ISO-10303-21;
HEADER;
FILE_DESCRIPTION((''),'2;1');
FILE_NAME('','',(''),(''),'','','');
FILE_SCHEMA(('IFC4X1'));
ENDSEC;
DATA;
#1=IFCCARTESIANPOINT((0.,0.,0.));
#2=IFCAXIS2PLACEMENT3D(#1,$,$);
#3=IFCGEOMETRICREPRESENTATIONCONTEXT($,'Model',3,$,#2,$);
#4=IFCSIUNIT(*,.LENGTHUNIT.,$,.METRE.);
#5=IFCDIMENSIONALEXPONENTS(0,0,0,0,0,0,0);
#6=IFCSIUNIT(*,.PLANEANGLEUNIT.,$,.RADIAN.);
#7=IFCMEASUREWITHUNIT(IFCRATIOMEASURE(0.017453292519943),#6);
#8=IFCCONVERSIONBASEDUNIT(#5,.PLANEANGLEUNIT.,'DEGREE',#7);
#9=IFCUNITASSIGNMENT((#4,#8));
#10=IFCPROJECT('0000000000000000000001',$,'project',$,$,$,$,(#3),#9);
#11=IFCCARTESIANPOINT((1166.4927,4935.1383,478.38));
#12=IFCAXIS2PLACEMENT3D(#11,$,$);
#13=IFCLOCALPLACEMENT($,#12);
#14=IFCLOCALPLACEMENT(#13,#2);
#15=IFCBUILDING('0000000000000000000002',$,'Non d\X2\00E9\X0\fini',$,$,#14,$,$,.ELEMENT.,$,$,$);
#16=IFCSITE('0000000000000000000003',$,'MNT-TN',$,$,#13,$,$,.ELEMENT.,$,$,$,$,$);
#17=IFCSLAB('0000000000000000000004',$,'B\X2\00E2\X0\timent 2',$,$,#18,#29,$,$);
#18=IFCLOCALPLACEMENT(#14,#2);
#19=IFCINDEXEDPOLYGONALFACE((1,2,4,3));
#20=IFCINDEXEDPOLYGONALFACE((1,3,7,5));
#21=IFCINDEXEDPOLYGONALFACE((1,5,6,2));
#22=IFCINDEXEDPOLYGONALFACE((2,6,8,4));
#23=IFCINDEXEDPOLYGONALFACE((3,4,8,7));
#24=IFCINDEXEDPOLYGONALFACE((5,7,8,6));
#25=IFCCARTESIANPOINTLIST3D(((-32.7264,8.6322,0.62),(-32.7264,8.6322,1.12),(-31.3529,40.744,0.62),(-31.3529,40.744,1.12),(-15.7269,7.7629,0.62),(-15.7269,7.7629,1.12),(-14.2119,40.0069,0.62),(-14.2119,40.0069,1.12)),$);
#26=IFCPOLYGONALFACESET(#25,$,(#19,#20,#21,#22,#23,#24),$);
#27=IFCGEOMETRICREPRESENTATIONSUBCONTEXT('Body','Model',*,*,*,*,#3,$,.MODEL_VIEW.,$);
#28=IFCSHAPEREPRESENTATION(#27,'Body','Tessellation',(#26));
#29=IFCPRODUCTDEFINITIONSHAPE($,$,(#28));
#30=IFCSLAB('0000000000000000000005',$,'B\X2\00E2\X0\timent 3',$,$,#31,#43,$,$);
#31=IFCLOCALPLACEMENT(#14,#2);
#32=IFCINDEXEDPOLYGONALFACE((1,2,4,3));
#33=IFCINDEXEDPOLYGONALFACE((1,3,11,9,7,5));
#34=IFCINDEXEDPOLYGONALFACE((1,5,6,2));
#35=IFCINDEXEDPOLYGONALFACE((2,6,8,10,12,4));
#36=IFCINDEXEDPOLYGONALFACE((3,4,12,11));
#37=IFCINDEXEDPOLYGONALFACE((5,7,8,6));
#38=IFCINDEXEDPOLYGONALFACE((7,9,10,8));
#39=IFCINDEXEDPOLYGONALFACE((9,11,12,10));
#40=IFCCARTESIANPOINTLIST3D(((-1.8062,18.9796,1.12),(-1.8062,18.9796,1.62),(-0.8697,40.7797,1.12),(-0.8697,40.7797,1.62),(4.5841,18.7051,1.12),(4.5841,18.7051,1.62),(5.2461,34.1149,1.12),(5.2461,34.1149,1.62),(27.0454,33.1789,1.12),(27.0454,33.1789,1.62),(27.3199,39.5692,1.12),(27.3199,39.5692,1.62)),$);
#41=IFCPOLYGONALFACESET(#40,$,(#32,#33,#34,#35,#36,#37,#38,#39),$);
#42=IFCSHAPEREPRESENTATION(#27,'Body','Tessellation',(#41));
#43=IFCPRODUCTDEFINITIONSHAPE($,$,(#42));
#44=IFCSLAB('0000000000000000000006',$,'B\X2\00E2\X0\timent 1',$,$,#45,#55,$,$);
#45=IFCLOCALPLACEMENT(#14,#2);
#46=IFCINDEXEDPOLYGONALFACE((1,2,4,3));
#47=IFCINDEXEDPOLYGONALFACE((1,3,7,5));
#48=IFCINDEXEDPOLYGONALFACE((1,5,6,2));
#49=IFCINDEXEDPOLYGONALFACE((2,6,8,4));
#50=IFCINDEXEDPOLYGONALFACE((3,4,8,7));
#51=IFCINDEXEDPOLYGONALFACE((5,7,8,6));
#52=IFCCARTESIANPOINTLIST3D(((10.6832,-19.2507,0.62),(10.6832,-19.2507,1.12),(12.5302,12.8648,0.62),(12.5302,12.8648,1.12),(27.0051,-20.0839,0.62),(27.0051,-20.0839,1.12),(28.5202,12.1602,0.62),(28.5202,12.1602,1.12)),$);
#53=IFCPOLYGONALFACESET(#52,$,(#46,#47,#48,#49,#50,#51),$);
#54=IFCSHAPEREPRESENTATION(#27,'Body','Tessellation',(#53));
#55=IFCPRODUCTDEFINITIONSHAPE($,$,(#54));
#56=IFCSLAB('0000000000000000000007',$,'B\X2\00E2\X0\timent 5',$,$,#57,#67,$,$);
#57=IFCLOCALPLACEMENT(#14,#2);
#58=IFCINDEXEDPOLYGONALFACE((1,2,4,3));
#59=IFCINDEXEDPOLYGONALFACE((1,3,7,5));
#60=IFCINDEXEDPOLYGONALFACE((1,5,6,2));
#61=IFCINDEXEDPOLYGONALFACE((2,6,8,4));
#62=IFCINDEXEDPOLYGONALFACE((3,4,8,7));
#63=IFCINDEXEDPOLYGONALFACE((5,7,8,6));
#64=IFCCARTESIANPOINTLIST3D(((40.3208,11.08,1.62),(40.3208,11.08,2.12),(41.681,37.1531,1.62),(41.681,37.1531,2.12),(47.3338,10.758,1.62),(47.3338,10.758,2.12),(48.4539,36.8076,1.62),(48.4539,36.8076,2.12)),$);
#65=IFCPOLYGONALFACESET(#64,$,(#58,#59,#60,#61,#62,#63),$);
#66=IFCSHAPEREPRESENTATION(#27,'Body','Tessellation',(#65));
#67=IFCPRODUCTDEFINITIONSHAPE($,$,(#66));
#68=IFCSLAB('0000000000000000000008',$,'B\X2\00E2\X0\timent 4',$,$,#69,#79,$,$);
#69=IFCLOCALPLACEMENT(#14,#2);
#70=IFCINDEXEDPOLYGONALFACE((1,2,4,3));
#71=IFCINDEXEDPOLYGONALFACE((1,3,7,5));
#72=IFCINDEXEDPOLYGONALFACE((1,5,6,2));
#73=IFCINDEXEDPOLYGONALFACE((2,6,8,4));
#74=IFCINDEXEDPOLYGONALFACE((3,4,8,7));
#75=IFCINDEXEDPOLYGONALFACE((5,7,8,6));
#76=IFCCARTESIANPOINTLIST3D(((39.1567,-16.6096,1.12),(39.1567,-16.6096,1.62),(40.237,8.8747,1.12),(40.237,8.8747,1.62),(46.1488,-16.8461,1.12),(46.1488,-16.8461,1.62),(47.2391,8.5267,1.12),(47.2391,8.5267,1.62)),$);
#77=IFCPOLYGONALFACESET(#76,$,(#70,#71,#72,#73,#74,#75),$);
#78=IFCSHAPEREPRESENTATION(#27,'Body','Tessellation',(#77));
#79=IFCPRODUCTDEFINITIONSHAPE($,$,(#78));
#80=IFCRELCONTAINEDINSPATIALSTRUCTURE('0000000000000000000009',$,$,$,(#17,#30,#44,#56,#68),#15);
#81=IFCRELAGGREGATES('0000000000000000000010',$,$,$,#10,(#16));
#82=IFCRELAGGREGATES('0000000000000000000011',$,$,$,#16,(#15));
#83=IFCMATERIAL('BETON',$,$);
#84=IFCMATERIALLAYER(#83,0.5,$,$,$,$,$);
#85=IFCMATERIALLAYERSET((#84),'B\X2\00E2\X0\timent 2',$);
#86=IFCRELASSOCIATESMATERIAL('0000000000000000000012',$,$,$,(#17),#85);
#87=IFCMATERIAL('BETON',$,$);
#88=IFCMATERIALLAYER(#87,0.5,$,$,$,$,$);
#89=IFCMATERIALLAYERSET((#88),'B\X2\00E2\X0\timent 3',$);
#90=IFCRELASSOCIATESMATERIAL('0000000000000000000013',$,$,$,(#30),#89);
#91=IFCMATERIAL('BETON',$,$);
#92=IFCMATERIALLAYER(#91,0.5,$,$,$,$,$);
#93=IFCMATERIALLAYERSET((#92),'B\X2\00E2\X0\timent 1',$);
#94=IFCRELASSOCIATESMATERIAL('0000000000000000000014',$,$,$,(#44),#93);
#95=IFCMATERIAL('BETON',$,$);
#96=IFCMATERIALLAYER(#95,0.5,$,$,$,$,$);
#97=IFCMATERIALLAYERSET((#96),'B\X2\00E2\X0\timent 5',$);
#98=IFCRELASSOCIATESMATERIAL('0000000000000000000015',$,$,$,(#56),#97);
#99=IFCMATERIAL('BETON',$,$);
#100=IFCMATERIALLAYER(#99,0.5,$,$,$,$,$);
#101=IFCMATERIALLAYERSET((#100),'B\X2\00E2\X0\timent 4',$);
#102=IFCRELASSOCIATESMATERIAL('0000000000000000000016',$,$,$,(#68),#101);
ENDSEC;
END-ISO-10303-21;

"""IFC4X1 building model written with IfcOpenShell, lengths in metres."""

from ifc_helpers import new_model, entity, si_unit, converted_unit, frame, origin, place, context, subcontext, project, spatial, polyline, outline, extrude, material, layer, layer_set, layer_usage, element, save


model = new_model("IFC4X1")

# Units and contexts
model_context = context("Model", 3, world=origin())
body_context = subcontext(model_context, "Body", "Model", "MODEL_VIEW")
ifc_project = project(units=[si_unit("LENGTHUNIT", "METRE"), converted_unit("PLANEANGLEUNIT", "DEGREE", entity("IfcRatioMeasure", 0.017453292519943), si_unit("PLANEANGLEUNIT", "RADIAN"), dimensions=[0, 0, 0, 0, 0, 0, 0])], contexts=[model_context])

# Site, building
site_placement = place(None, frame((1166.4927, 4935.1383, 478.38)))
site = spatial("IfcSite", under=ifc_project, at=site_placement, Name="MNT-TN", CompositionType="ELEMENT")
building_placement = place(site_placement, origin())
building = spatial("IfcBuilding", under=site, at=building_placement, Name="Non défini", CompositionType="ELEMENT")

# Slabs
ifc_material_1 = material(Name="BETON")
ifc_layer_1 = layer(ifc_material_1, 0.5)
ifc_layer_set_1 = layer_set([ifc_layer_1], Name="Bâtiment 2")
ifc_layer_usage_1 = layer_usage(ifc_layer_set_1, "AXIS3", "POSITIVE", 0.0)
slab_1_placement = place(building_placement, origin())
element("IfcSlab", 1, at=slab_1_placement, inside=building, material=ifc_layer_usage_1, Name="Bâtiment 2", context=body_context, shape_type="SweptSolid", body=[
    extrude(outline(polyline([(0.0, 0.0), (17.1411, -0.7371), (15.626, -32.9811), (-1.3735, -32.1118), (0.0, 0.0)])), frame((-31.3529, 40.744, 1.12), z_axis=(0.0, 0.0, 1.0), x_axis=(1.0, 0.0, 0.0)), (0.0, 0.0, -1.0), 0.5),
])
ifc_material_2 = material(Name="BETON")
ifc_layer_2 = layer(ifc_material_2, 0.5)
ifc_layer_set_2 = layer_set([ifc_layer_2], Name="Bâtiment 3")
ifc_layer_usage_2 = layer_usage(ifc_layer_set_2, "AXIS3", "POSITIVE", 0.0)
slab_2_placement = place(building_placement, origin())
element("IfcSlab", 2, at=slab_2_placement, inside=building, material=ifc_layer_usage_2, Name="Bâtiment 3", context=body_context, shape_type="SweptSolid", body=[
    extrude(outline(polyline([(0.0, 0.0), (28.1896, -1.2105), (27.9151, -7.6008), (6.1158, -6.6648), (5.4539, -22.0746), (-0.9364, -21.8001), (0.0, 0.0)])), frame((-0.8697, 40.7797, 1.62), z_axis=(0.0, 0.0, 1.0), x_axis=(1.0, 0.0, 0.0)), (0.0, 0.0, -1.0), 0.5),
])
ifc_material_3 = material(Name="BETON")
ifc_layer_3 = layer(ifc_material_3, 0.5)
ifc_layer_set_3 = layer_set([ifc_layer_3], Name="Bâtiment 1")
ifc_layer_usage_3 = layer_usage(ifc_layer_set_3, "AXIS3", "POSITIVE", 0.0)
slab_3_placement = place(building_placement, origin())
element("IfcSlab", 3, at=slab_3_placement, inside=building, material=ifc_layer_usage_3, Name="Bâtiment 1", context=body_context, shape_type="SweptSolid", body=[
    extrude(outline(polyline([(0.0, 0.0), (-1.515, -32.244), (-17.837, -31.4109), (-15.99, 0.7046), (0.0, 0.0)])), frame((28.5202, 12.1602, 1.12), z_axis=(0.0, 0.0, 1.0), x_axis=(1.0, 0.0, 0.0)), (0.0, 0.0, -1.0), 0.5),
])
ifc_material_4 = material(Name="BETON")
ifc_layer_4 = layer(ifc_material_4, 0.5)
ifc_layer_set_4 = layer_set([ifc_layer_4], Name="Bâtiment 5")
ifc_layer_usage_4 = layer_usage(ifc_layer_set_4, "AXIS3", "POSITIVE", 0.0)
slab_4_placement = place(building_placement, origin())
element("IfcSlab", 4, at=slab_4_placement, inside=building, material=ifc_layer_usage_4, Name="Bâtiment 5", context=body_context, shape_type="SweptSolid", body=[
    extrude(outline(polyline([(0.0, 0.0), (6.7729, -0.3456), (5.6529, -26.3951), (-1.3602, -26.0731), (0.0, 0.0)])), frame((41.681, 37.1531, 2.12), z_axis=(0.0, 0.0, 1.0), x_axis=(1.0, 0.0, 0.0)), (0.0, 0.0, -1.0), 0.5),
])
ifc_material_5 = material(Name="BETON")
ifc_layer_5 = layer(ifc_material_5, 0.5)
ifc_layer_set_5 = layer_set([ifc_layer_5], Name="Bâtiment 4")
ifc_layer_usage_5 = layer_usage(ifc_layer_set_5, "AXIS3", "POSITIVE", 0.0)
slab_5_placement = place(building_placement, origin())
element("IfcSlab", 5, at=slab_5_placement, inside=building, material=ifc_layer_usage_5, Name="Bâtiment 4", context=body_context, shape_type="SweptSolid", body=[
    extrude(outline(polyline([(0.0, 0.0), (7.0021, -0.348), (5.9118, -25.7209), (-1.0803, -25.4843), (0.0, 0.0)])), frame((40.237, 8.8747, 1.62), z_axis=(0.0, 0.0, 1.0), x_axis=(1.0, 0.0, 0.0)), (0.0, 0.0, -1.0), 0.5),
])

save(model, "model.ifc")
